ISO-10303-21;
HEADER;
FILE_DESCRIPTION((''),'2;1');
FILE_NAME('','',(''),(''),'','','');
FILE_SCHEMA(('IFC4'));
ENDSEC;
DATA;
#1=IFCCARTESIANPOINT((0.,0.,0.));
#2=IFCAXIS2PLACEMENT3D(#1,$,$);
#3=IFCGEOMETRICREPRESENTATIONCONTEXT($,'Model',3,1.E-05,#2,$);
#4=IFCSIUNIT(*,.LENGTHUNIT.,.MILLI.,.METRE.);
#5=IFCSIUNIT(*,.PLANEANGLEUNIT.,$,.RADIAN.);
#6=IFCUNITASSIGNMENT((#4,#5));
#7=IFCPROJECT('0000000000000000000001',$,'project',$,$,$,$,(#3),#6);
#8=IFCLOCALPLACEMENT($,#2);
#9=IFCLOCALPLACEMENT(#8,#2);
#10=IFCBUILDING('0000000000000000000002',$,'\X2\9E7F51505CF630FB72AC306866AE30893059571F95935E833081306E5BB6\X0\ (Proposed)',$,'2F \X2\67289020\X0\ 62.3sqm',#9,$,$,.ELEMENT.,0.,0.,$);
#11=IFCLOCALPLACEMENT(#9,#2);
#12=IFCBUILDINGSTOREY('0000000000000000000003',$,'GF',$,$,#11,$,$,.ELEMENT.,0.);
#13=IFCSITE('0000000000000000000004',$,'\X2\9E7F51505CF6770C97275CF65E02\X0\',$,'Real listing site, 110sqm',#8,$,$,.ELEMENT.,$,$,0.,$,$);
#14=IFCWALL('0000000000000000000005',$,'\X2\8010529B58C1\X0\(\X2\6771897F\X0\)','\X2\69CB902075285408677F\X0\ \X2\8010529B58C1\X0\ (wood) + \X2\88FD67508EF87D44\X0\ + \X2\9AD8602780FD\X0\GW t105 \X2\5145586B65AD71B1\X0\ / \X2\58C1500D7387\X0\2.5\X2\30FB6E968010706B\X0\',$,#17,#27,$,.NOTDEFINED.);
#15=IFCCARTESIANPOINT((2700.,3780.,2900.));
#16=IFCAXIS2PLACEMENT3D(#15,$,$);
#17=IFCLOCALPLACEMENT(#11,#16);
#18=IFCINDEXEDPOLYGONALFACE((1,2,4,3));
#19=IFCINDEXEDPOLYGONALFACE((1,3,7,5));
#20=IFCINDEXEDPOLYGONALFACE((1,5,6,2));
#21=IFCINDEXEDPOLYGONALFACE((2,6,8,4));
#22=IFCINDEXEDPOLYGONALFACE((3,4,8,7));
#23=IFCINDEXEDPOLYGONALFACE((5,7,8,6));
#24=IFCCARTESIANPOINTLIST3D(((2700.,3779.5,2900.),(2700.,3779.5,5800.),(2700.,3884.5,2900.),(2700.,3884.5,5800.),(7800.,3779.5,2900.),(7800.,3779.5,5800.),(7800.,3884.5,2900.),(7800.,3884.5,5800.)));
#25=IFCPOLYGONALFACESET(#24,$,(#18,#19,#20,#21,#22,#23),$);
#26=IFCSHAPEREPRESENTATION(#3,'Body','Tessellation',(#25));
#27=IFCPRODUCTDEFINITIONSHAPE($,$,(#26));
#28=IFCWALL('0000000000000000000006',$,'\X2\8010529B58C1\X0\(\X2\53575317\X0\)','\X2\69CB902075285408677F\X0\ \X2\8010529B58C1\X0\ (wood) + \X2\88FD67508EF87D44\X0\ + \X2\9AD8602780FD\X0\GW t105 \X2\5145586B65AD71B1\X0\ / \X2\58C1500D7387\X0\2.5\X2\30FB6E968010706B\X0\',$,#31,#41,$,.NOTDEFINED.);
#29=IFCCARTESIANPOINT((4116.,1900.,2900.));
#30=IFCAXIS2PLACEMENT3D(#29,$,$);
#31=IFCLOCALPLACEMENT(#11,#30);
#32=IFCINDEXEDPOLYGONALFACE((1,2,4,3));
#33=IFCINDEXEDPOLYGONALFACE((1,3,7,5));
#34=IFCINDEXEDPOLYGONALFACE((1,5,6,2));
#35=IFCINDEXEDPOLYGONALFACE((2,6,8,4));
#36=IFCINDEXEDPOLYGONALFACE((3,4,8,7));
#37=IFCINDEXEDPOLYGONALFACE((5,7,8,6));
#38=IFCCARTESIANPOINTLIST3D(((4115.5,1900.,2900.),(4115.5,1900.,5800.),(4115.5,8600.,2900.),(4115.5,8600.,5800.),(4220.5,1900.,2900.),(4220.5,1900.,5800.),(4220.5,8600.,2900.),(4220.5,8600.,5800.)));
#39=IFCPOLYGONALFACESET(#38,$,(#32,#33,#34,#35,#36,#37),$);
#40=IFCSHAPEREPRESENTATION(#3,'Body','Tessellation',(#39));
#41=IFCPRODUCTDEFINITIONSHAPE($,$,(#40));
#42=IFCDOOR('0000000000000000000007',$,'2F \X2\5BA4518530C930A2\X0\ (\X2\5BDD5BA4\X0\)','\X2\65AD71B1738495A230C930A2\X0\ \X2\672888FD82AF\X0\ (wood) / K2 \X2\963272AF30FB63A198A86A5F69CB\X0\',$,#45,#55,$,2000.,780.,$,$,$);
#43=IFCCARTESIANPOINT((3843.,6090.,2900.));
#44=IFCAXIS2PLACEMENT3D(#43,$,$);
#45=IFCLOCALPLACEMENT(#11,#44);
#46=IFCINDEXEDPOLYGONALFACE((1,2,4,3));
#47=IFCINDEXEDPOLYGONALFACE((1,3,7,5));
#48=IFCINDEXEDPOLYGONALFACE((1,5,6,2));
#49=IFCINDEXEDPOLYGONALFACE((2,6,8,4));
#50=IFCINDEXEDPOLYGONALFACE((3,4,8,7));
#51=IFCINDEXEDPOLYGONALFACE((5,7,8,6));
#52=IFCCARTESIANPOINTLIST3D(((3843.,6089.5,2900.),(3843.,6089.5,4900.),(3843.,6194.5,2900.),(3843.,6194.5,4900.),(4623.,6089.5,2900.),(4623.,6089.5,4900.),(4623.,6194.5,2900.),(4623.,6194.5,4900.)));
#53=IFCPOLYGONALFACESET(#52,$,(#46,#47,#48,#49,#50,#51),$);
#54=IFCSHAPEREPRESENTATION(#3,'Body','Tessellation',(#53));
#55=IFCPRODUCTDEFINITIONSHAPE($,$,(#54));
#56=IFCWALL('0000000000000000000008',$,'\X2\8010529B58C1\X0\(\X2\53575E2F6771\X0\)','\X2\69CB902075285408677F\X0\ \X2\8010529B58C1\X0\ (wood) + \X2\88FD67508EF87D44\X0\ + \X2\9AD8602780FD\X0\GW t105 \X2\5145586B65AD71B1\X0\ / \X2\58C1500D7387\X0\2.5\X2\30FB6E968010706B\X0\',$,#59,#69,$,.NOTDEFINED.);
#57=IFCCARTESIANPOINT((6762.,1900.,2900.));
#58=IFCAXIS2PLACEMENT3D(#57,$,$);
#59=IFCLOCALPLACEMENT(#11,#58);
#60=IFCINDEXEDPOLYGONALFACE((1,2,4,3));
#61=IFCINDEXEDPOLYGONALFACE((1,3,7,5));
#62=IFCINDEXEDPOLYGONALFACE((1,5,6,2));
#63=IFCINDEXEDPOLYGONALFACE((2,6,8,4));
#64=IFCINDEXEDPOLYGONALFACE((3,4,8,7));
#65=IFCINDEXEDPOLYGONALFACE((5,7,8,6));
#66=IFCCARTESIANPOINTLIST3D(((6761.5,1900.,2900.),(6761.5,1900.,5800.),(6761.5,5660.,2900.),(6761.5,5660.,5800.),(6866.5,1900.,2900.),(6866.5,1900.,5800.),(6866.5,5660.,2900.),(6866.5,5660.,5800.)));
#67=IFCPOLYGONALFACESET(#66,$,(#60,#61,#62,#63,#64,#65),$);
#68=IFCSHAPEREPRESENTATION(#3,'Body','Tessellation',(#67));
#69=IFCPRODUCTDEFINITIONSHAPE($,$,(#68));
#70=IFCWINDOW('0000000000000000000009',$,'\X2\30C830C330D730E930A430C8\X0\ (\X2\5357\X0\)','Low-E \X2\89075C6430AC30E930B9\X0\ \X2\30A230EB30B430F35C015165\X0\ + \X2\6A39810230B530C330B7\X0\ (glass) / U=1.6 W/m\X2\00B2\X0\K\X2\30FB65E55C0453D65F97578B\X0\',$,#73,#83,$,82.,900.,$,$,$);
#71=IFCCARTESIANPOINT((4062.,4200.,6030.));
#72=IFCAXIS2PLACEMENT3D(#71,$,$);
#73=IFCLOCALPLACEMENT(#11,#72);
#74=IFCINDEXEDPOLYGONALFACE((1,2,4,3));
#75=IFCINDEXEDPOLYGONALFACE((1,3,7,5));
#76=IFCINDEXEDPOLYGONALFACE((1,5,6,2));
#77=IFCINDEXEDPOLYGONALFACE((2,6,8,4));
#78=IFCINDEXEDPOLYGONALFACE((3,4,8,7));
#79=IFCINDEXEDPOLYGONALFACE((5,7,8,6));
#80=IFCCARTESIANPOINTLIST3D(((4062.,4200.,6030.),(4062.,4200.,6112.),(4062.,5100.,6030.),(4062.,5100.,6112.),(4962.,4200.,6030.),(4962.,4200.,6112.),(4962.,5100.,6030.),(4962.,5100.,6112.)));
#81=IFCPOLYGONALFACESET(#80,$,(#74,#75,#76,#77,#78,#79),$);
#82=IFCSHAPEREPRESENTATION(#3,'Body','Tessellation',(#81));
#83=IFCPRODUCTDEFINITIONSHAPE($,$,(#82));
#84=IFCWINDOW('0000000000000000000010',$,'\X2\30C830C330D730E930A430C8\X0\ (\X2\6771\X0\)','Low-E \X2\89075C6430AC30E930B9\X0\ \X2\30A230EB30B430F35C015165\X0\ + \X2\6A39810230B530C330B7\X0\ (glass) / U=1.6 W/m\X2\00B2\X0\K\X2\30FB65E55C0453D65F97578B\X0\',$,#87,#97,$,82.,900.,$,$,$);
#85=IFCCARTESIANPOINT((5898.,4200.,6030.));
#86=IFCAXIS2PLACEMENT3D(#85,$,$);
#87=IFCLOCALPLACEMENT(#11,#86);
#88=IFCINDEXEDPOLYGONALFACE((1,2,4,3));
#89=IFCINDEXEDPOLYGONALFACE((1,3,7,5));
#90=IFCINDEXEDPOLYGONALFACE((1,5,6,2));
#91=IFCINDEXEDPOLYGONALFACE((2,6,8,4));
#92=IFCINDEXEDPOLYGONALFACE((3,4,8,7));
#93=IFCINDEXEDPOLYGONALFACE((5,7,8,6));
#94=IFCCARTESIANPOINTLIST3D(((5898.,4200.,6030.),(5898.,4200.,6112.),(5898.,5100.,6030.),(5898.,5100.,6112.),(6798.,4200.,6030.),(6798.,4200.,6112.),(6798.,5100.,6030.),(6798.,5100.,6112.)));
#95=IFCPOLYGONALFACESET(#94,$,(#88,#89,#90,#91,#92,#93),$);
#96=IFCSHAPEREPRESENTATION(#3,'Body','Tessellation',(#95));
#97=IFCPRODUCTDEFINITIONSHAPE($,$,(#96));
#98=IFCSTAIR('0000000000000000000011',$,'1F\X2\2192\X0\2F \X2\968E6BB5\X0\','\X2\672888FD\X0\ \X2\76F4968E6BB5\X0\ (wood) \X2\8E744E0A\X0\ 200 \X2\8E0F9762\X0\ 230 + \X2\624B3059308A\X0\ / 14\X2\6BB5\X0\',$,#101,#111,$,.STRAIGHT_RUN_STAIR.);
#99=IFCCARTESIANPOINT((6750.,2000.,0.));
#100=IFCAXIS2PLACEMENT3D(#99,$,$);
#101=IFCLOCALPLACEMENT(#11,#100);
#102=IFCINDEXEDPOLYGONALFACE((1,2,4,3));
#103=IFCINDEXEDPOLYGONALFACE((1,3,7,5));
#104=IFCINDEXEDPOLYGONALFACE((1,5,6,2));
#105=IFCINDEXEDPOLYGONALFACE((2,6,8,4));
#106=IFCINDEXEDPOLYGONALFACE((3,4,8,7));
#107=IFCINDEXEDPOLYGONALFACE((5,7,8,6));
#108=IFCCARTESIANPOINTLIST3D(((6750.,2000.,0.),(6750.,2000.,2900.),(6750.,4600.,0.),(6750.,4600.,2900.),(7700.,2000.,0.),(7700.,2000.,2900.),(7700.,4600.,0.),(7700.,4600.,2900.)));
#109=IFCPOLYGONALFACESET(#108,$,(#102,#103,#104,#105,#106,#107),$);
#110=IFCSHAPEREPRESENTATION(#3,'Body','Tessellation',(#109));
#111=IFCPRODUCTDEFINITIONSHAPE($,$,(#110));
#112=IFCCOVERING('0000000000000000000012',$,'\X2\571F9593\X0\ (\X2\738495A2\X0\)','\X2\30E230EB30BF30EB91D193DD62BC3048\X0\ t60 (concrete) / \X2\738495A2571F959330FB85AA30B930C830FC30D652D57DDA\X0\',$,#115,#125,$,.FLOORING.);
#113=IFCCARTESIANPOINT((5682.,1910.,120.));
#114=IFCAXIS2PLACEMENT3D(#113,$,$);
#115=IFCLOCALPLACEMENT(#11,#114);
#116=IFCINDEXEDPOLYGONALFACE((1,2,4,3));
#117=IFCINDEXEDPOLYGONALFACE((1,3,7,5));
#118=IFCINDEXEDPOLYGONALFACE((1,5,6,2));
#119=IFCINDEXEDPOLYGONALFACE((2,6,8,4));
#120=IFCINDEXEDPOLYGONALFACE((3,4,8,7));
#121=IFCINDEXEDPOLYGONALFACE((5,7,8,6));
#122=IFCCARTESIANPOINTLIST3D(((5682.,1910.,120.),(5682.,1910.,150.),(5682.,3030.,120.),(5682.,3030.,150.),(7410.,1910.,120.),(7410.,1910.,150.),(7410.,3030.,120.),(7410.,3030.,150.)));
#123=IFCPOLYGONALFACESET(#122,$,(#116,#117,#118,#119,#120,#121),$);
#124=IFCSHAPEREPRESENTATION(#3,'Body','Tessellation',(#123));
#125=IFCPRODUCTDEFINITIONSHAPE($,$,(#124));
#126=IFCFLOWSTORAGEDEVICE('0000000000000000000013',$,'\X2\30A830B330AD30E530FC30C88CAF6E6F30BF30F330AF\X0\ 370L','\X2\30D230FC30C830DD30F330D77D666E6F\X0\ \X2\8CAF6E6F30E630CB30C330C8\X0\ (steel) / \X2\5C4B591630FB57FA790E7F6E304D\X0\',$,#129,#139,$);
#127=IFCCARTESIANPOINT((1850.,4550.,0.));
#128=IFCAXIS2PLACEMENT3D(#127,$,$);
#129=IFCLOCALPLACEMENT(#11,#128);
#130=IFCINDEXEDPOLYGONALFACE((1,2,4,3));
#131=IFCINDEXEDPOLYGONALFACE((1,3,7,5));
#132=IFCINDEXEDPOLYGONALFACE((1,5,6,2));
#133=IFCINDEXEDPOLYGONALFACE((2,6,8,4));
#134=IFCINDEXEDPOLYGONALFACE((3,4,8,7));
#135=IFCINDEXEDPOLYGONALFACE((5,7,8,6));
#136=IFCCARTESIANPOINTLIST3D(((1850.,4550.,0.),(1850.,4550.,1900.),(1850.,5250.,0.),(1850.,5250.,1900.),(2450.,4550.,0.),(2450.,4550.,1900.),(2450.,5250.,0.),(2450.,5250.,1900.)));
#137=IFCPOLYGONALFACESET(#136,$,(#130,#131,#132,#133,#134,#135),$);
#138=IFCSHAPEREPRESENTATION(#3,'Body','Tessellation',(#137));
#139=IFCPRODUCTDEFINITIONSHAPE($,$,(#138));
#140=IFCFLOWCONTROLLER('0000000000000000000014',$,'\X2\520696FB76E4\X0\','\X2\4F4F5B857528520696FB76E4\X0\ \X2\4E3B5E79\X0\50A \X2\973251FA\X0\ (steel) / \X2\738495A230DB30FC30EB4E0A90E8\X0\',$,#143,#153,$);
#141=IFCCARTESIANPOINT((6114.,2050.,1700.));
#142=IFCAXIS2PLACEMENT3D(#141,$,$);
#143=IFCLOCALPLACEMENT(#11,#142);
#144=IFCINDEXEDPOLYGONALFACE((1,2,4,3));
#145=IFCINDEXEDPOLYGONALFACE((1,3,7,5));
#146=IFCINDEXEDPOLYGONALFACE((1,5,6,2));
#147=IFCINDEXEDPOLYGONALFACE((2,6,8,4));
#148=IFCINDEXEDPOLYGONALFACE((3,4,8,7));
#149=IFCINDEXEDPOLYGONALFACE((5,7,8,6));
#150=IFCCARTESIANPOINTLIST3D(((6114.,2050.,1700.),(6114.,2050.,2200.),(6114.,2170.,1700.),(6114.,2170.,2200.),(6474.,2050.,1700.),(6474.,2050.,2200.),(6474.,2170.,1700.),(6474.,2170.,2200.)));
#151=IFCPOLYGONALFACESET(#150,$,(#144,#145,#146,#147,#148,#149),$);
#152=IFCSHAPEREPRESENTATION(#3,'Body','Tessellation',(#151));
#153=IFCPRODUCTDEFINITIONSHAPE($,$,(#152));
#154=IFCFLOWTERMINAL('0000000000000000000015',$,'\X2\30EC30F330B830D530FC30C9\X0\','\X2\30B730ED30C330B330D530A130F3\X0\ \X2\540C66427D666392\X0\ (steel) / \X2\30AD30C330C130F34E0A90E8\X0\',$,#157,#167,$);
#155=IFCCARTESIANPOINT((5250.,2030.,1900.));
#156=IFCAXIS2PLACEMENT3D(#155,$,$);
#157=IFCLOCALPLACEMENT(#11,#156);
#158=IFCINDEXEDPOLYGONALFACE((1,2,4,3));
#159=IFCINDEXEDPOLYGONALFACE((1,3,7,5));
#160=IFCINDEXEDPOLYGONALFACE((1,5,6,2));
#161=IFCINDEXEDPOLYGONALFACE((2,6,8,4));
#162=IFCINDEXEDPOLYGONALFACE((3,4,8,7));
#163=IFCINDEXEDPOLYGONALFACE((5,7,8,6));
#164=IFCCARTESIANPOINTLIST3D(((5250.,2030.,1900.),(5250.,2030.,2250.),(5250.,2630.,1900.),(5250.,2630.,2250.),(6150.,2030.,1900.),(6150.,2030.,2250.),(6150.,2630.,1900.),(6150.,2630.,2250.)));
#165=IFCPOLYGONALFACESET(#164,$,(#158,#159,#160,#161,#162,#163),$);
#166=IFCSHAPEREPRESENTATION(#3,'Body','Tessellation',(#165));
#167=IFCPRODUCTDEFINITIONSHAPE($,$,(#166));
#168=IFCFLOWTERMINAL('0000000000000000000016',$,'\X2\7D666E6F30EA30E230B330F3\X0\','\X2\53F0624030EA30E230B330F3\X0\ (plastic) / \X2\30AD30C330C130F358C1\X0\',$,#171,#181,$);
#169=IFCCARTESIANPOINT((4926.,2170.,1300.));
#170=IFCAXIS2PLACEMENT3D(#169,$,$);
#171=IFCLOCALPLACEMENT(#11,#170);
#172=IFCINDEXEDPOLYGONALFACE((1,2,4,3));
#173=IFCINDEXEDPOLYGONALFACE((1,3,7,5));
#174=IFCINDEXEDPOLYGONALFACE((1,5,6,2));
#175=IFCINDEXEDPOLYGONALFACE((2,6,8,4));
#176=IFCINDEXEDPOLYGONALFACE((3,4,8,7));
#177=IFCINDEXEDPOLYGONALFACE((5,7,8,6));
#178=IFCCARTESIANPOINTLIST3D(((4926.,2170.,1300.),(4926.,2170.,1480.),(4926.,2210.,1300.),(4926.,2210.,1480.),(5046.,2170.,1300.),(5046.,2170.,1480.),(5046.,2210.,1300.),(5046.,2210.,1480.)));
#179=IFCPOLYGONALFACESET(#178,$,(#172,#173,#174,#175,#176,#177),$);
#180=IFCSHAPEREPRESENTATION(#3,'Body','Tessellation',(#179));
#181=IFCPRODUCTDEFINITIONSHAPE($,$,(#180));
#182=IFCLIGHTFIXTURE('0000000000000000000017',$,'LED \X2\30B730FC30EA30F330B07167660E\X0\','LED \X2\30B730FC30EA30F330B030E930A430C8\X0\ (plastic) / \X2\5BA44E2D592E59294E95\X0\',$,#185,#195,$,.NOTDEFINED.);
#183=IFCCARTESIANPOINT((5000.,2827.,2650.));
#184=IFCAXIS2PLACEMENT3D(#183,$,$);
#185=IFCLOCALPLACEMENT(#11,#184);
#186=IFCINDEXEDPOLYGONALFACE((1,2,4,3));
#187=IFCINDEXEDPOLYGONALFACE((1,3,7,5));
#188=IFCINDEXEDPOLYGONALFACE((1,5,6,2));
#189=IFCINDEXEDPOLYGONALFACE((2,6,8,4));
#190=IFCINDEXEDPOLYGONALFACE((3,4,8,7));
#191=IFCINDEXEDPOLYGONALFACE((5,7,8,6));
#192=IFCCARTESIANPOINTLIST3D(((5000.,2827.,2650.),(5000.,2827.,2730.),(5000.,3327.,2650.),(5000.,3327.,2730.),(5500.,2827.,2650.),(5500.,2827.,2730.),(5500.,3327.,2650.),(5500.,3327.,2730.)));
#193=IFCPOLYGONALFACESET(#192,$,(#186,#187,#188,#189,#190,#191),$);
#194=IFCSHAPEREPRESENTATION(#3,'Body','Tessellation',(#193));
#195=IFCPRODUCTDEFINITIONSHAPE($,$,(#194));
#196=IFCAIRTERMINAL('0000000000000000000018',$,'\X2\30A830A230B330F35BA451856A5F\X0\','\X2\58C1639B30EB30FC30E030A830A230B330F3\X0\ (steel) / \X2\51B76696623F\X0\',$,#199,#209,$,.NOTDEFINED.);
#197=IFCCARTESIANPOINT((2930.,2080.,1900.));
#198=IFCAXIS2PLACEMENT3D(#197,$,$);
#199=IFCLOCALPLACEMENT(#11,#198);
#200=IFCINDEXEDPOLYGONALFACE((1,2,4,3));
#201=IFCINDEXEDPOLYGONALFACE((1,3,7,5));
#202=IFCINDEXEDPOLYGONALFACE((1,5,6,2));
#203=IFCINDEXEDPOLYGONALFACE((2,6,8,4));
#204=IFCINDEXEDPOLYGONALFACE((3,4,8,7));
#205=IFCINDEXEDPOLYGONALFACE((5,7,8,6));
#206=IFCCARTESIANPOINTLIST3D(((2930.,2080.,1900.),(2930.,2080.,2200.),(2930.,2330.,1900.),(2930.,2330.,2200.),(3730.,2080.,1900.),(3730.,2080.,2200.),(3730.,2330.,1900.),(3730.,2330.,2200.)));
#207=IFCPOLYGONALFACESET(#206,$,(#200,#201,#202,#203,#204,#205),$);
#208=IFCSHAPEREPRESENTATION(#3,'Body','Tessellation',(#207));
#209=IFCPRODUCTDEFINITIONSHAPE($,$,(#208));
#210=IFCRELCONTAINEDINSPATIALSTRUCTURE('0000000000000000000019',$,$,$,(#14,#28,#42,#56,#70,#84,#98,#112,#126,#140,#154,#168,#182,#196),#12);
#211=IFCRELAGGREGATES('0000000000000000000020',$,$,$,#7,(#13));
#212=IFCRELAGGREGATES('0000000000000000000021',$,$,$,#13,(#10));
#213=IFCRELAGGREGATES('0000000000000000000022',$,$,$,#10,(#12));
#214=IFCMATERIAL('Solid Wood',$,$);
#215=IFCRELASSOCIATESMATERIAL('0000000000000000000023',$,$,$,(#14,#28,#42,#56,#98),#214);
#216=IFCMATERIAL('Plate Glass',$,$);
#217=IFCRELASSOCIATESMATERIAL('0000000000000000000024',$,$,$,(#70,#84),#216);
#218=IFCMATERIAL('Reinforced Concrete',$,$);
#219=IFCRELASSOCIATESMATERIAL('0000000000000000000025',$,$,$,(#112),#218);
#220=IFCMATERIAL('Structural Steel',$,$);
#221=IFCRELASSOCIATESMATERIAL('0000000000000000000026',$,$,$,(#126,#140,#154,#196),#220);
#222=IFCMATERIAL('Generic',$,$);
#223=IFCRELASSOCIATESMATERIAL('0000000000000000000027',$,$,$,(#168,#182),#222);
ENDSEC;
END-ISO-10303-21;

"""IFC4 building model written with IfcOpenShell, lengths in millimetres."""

from ifc_helpers import new_model, si_unit, frame, frame_2d, origin, place, context, project, spatial, rectangle, extrude, material, element, fill, save


model = new_model("IFC4")

# Units and contexts
model_context = context("Model", 3, precision=1e-05, world=origin())
ifc_project = project(units=[si_unit("LENGTHUNIT", "METRE", prefix="MILLI"), si_unit("PLANEANGLEUNIT", "RADIAN")], contexts=[model_context])

# Site, building, storey
site_placement = place(None, origin())
site = spatial("IfcSite", under=ifc_project, at=site_placement, Name="鹿児島県霧島市", ObjectType="Real listing site, 110sqm", CompositionType="ELEMENT", RefElevation=0.0)
building_placement = place(site_placement, origin())
building = spatial("IfcBuilding", under=site, at=building_placement, Name="鹿児島・犬と暮らす土間広めの家 (Proposed)", ObjectType="2F 木造 62.3sqm", CompositionType="ELEMENT", ElevationOfRefHeight=0.0, ElevationOfTerrain=0.0)
storey_placement = place(building_placement, origin())
storey = spatial("IfcBuildingStorey", under=building, at=storey_placement, Name="GF", CompositionType="ELEMENT", Elevation=0.0)

# Shared definitions
ifc_material_1 = material(Name="Solid Wood")

# Wall
wall_1_placement = place(storey_placement, frame((2700.0, 3780.0, 2900.0)))
element("IfcWall", 1, at=wall_1_placement, inside=storey, material=ifc_material_1, Name="耐力壁(東西)", Description="構造用合板 耐力壁 (wood) + 製材軸組 + 高性能GW t105 充填断熱 / 壁倍率2.5・準耐火", PredefinedType="NOTDEFINED", context=model_context, shape_type="SweptSolid", body=[
    extrude(rectangle(XDim=5100.0, YDim=105.0, at=frame_2d((2550.0, 52.0))), frame((2700.0, 3780.0, 2900.0)), (0.0, 0.0, 1.0), 2900.0),
])

# Wall, opening, door
wall_2_placement = place(storey_placement, frame((4116.0, 1900.0, 2900.0)))
wall_2 = element("IfcWall", 2, at=wall_2_placement, inside=storey, material=ifc_material_1, Name="耐力壁(南北)", Description="構造用合板 耐力壁 (wood) + 製材軸組 + 高性能GW t105 充填断熱 / 壁倍率2.5・準耐火", PredefinedType="NOTDEFINED", context=model_context, shape_type="SweptSolid", body=[
    extrude(rectangle(XDim=105.0, YDim=6700.0, at=frame_2d((52.0, 3350.0))), frame((4116.0, 1900.0, 2900.0)), (0.0, 0.0, 1.0), 2900.0),
])
opening_placement = place(storey_placement, frame((3843.0, 6090.0, 2900.0)))
opening = element("IfcOpeningElement", 3, at=opening_placement, cuts=wall_2, PredefinedType="NOTDEFINED", context=model_context, shape_type="SweptSolid", body=[
    extrude(rectangle(XDim=780.0, YDim=105.0, at=frame_2d((390.0, 52.0))), frame((3843.0, 6090.0, 2900.0)), (0.0, 0.0, 1.0), 2000.0),
])
door_placement = place(storey_placement, frame((3843.0, 6090.0, 2900.0)))
door = element("IfcDoor", 4, at=door_placement, inside=storey, material=ifc_material_1, Name="2F 室内ドア (寝室)", Description="断熱玄関ドア 木製芯 (wood) / K2 防犯・採風機構", OverallHeight=2000.0, OverallWidth=780.0, context=model_context, shape_type="SweptSolid", body=[
    extrude(rectangle(XDim=780.0, YDim=105.0, at=frame_2d((390.0, 52.0))), frame((3843.0, 6090.0, 2900.0)), (0.0, 0.0, 1.0), 2000.0),
])
fill(opening, door)

# Wall
wall_3_placement = place(storey_placement, frame((6762.0, 1900.0, 2900.0)))
element("IfcWall", 5, at=wall_3_placement, inside=storey, material=ifc_material_1, Name="耐力壁(南帯東)", Description="構造用合板 耐力壁 (wood) + 製材軸組 + 高性能GW t105 充填断熱 / 壁倍率2.5・準耐火", PredefinedType="NOTDEFINED", context=model_context, shape_type="SweptSolid", body=[
    extrude(rectangle(XDim=105.0, YDim=3760.0, at=frame_2d((52.0, 1880.0))), frame((6762.0, 1900.0, 2900.0)), (0.0, 0.0, 1.0), 2900.0),
])

# Windows
ifc_material_2 = material(Name="Plate Glass")
window_1_placement = place(storey_placement, frame((4062.0, 4200.0, 6030.0)))
element("IfcWindow", 6, at=window_1_placement, inside=storey, material=ifc_material_2, Name="トップライト (南)", Description="Low-E 複層ガラス アルゴン封入 + 樹脂サッシ (glass) / U=1.6 W/m²K・日射取得型", OverallHeight=82.0, OverallWidth=900.0, context=model_context, shape_type="SweptSolid", body=[
    extrude(rectangle(XDim=900.0, YDim=900.0, at=frame_2d((450.0, 450.0))), frame((4062.0, 4200.0, 6030.0)), (0.0, 0.0, 1.0), 82.0),
])
window_2_placement = place(storey_placement, frame((5898.0, 4200.0, 6030.0)))
element("IfcWindow", 7, at=window_2_placement, inside=storey, material=ifc_material_2, Name="トップライト (東)", Description="Low-E 複層ガラス アルゴン封入 + 樹脂サッシ (glass) / U=1.6 W/m²K・日射取得型", OverallHeight=82.0, OverallWidth=900.0, context=model_context, shape_type="SweptSolid", body=[
    extrude(rectangle(XDim=900.0, YDim=900.0, at=frame_2d((450.0, 450.0))), frame((5898.0, 4200.0, 6030.0)), (0.0, 0.0, 1.0), 82.0),
])

# Stair
stair_placement = place(storey_placement, frame((6750.0, 2000.0, 0.0)))
element("IfcStair", 8, at=stair_placement, inside=storey, material=ifc_material_1, Name="1F→2F 階段", Description="木製 直階段 (wood) 蹴上 200 踏面 230 + 手すり / 14段", PredefinedType="STRAIGHT_RUN_STAIR", context=model_context, shape_type="SweptSolid", body=[
    extrude(rectangle(XDim=950.0, YDim=2600.0, at=frame_2d((475.0, 1300.0))), frame((6750.0, 2000.0, 0.0)), (0.0, 0.0, 1.0), 2900.0),
])

# Covering
ifc_material_3 = material(Name="Reinforced Concrete")
covering_placement = place(storey_placement, frame((5682.0, 1910.0, 120.0)))
element("IfcCovering", 9, at=covering_placement, inside=storey, material=ifc_material_3, Name="土間 (玄関)", Description="モルタル金鏝押え t60 (concrete) / 玄関土間・薪ストーブ動線", PredefinedType="FLOORING", context=model_context, shape_type="SweptSolid", body=[
    extrude(rectangle(XDim=1728.0, YDim=1120.0, at=frame_2d((864.0, 560.0))), frame((5682.0, 1910.0, 120.0)), (0.0, 0.0, 1.0), 30.0),
])

# Flow storage device
ifc_material_4 = material(Name="Structural Steel")
flow_storage_device_placement = place(storey_placement, frame((1850.0, 4550.0, 0.0)))
element("IfcFlowStorageDevice", 10, at=flow_storage_device_placement, inside=storey, material=ifc_material_4, Name="エコキュート貯湯タンク 370L", Description="ヒートポンプ給湯 貯湯ユニット (steel) / 屋外・基礎置き", context=model_context, shape_type="SweptSolid", body=[
    extrude(rectangle(XDim=600.0, YDim=700.0, at=frame_2d((300.0, 350.0))), frame((1850.0, 4550.0, 0.0)), (0.0, 0.0, 1.0), 1900.0),
])

# Flow controller
flow_controller_placement = place(storey_placement, frame((6114.0, 2050.0, 1700.0)))
element("IfcFlowController", 11, at=flow_controller_placement, inside=storey, material=ifc_material_4, Name="分電盤", Description="住宅用分電盤 主幹50A 露出 (steel) / 玄関ホール上部", context=model_context, shape_type="SweptSolid", body=[
    extrude(rectangle(XDim=360.0, YDim=120.0, at=frame_2d((180.0, 60.0))), frame((6114.0, 2050.0, 1700.0)), (0.0, 0.0, 1.0), 500.0),
])

# Flow terminals
flow_terminal_1_placement = place(storey_placement, frame((5250.0, 2030.0, 1900.0)))
element("IfcFlowTerminal", 12, at=flow_terminal_1_placement, inside=storey, material=ifc_material_4, Name="レンジフード", Description="シロッコファン 同時給排 (steel) / キッチン上部", context=model_context, shape_type="SweptSolid", body=[
    extrude(rectangle(XDim=900.0, YDim=600.0, at=frame_2d((450.0, 300.0))), frame((5250.0, 2030.0, 1900.0)), (0.0, 0.0, 1.0), 350.0),
])
ifc_material_5 = material(Name="Generic")
flow_terminal_2_placement = place(storey_placement, frame((4926.0, 2170.0, 1300.0)))
element("IfcFlowTerminal", 13, at=flow_terminal_2_placement, inside=storey, material=ifc_material_5, Name="給湯リモコン", Description="台所リモコン (plastic) / キッチン壁", context=model_context, shape_type="SweptSolid", body=[
    extrude(rectangle(XDim=120.0, YDim=40.0, at=frame_2d((60.0, 20.0))), frame((4926.0, 2170.0, 1300.0)), (0.0, 0.0, 1.0), 180.0),
])

# Light fixture
light_fixture_1_placement = place(storey_placement, frame((5000.0, 2827.0, 2650.0)))
element("IfcLightFixture", 14, at=light_fixture_1_placement, inside=storey, material=ifc_material_5, Name="LED シーリング照明", Description="LED シーリングライト (plastic) / 室中央天井", PredefinedType="NOTDEFINED", context=model_context, shape_type="SweptSolid", body=[
    extrude(rectangle(XDim=500.0, YDim=500.0, at=frame_2d((250.0, 250.0))), frame((5000.0, 2827.0, 2650.0)), (0.0, 0.0, 1.0), 80.0),
])

# Air terminal
air_terminal_1_placement = place(storey_placement, frame((2930.0, 2080.0, 1900.0)))
element("IfcAirTerminal", 15, at=air_terminal_1_placement, inside=storey, material=ifc_material_4, Name="エアコン室内機", Description="壁掛ルームエアコン (steel) / 冷暖房", PredefinedType="NOTDEFINED", context=model_context, shape_type="SweptSolid", body=[
    extrude(rectangle(XDim=800.0, YDim=250.0, at=frame_2d((400.0, 125.0))), frame((2930.0, 2080.0, 1900.0)), (0.0, 0.0, 1.0), 300.0),
])

save(model, "model.ifc")
